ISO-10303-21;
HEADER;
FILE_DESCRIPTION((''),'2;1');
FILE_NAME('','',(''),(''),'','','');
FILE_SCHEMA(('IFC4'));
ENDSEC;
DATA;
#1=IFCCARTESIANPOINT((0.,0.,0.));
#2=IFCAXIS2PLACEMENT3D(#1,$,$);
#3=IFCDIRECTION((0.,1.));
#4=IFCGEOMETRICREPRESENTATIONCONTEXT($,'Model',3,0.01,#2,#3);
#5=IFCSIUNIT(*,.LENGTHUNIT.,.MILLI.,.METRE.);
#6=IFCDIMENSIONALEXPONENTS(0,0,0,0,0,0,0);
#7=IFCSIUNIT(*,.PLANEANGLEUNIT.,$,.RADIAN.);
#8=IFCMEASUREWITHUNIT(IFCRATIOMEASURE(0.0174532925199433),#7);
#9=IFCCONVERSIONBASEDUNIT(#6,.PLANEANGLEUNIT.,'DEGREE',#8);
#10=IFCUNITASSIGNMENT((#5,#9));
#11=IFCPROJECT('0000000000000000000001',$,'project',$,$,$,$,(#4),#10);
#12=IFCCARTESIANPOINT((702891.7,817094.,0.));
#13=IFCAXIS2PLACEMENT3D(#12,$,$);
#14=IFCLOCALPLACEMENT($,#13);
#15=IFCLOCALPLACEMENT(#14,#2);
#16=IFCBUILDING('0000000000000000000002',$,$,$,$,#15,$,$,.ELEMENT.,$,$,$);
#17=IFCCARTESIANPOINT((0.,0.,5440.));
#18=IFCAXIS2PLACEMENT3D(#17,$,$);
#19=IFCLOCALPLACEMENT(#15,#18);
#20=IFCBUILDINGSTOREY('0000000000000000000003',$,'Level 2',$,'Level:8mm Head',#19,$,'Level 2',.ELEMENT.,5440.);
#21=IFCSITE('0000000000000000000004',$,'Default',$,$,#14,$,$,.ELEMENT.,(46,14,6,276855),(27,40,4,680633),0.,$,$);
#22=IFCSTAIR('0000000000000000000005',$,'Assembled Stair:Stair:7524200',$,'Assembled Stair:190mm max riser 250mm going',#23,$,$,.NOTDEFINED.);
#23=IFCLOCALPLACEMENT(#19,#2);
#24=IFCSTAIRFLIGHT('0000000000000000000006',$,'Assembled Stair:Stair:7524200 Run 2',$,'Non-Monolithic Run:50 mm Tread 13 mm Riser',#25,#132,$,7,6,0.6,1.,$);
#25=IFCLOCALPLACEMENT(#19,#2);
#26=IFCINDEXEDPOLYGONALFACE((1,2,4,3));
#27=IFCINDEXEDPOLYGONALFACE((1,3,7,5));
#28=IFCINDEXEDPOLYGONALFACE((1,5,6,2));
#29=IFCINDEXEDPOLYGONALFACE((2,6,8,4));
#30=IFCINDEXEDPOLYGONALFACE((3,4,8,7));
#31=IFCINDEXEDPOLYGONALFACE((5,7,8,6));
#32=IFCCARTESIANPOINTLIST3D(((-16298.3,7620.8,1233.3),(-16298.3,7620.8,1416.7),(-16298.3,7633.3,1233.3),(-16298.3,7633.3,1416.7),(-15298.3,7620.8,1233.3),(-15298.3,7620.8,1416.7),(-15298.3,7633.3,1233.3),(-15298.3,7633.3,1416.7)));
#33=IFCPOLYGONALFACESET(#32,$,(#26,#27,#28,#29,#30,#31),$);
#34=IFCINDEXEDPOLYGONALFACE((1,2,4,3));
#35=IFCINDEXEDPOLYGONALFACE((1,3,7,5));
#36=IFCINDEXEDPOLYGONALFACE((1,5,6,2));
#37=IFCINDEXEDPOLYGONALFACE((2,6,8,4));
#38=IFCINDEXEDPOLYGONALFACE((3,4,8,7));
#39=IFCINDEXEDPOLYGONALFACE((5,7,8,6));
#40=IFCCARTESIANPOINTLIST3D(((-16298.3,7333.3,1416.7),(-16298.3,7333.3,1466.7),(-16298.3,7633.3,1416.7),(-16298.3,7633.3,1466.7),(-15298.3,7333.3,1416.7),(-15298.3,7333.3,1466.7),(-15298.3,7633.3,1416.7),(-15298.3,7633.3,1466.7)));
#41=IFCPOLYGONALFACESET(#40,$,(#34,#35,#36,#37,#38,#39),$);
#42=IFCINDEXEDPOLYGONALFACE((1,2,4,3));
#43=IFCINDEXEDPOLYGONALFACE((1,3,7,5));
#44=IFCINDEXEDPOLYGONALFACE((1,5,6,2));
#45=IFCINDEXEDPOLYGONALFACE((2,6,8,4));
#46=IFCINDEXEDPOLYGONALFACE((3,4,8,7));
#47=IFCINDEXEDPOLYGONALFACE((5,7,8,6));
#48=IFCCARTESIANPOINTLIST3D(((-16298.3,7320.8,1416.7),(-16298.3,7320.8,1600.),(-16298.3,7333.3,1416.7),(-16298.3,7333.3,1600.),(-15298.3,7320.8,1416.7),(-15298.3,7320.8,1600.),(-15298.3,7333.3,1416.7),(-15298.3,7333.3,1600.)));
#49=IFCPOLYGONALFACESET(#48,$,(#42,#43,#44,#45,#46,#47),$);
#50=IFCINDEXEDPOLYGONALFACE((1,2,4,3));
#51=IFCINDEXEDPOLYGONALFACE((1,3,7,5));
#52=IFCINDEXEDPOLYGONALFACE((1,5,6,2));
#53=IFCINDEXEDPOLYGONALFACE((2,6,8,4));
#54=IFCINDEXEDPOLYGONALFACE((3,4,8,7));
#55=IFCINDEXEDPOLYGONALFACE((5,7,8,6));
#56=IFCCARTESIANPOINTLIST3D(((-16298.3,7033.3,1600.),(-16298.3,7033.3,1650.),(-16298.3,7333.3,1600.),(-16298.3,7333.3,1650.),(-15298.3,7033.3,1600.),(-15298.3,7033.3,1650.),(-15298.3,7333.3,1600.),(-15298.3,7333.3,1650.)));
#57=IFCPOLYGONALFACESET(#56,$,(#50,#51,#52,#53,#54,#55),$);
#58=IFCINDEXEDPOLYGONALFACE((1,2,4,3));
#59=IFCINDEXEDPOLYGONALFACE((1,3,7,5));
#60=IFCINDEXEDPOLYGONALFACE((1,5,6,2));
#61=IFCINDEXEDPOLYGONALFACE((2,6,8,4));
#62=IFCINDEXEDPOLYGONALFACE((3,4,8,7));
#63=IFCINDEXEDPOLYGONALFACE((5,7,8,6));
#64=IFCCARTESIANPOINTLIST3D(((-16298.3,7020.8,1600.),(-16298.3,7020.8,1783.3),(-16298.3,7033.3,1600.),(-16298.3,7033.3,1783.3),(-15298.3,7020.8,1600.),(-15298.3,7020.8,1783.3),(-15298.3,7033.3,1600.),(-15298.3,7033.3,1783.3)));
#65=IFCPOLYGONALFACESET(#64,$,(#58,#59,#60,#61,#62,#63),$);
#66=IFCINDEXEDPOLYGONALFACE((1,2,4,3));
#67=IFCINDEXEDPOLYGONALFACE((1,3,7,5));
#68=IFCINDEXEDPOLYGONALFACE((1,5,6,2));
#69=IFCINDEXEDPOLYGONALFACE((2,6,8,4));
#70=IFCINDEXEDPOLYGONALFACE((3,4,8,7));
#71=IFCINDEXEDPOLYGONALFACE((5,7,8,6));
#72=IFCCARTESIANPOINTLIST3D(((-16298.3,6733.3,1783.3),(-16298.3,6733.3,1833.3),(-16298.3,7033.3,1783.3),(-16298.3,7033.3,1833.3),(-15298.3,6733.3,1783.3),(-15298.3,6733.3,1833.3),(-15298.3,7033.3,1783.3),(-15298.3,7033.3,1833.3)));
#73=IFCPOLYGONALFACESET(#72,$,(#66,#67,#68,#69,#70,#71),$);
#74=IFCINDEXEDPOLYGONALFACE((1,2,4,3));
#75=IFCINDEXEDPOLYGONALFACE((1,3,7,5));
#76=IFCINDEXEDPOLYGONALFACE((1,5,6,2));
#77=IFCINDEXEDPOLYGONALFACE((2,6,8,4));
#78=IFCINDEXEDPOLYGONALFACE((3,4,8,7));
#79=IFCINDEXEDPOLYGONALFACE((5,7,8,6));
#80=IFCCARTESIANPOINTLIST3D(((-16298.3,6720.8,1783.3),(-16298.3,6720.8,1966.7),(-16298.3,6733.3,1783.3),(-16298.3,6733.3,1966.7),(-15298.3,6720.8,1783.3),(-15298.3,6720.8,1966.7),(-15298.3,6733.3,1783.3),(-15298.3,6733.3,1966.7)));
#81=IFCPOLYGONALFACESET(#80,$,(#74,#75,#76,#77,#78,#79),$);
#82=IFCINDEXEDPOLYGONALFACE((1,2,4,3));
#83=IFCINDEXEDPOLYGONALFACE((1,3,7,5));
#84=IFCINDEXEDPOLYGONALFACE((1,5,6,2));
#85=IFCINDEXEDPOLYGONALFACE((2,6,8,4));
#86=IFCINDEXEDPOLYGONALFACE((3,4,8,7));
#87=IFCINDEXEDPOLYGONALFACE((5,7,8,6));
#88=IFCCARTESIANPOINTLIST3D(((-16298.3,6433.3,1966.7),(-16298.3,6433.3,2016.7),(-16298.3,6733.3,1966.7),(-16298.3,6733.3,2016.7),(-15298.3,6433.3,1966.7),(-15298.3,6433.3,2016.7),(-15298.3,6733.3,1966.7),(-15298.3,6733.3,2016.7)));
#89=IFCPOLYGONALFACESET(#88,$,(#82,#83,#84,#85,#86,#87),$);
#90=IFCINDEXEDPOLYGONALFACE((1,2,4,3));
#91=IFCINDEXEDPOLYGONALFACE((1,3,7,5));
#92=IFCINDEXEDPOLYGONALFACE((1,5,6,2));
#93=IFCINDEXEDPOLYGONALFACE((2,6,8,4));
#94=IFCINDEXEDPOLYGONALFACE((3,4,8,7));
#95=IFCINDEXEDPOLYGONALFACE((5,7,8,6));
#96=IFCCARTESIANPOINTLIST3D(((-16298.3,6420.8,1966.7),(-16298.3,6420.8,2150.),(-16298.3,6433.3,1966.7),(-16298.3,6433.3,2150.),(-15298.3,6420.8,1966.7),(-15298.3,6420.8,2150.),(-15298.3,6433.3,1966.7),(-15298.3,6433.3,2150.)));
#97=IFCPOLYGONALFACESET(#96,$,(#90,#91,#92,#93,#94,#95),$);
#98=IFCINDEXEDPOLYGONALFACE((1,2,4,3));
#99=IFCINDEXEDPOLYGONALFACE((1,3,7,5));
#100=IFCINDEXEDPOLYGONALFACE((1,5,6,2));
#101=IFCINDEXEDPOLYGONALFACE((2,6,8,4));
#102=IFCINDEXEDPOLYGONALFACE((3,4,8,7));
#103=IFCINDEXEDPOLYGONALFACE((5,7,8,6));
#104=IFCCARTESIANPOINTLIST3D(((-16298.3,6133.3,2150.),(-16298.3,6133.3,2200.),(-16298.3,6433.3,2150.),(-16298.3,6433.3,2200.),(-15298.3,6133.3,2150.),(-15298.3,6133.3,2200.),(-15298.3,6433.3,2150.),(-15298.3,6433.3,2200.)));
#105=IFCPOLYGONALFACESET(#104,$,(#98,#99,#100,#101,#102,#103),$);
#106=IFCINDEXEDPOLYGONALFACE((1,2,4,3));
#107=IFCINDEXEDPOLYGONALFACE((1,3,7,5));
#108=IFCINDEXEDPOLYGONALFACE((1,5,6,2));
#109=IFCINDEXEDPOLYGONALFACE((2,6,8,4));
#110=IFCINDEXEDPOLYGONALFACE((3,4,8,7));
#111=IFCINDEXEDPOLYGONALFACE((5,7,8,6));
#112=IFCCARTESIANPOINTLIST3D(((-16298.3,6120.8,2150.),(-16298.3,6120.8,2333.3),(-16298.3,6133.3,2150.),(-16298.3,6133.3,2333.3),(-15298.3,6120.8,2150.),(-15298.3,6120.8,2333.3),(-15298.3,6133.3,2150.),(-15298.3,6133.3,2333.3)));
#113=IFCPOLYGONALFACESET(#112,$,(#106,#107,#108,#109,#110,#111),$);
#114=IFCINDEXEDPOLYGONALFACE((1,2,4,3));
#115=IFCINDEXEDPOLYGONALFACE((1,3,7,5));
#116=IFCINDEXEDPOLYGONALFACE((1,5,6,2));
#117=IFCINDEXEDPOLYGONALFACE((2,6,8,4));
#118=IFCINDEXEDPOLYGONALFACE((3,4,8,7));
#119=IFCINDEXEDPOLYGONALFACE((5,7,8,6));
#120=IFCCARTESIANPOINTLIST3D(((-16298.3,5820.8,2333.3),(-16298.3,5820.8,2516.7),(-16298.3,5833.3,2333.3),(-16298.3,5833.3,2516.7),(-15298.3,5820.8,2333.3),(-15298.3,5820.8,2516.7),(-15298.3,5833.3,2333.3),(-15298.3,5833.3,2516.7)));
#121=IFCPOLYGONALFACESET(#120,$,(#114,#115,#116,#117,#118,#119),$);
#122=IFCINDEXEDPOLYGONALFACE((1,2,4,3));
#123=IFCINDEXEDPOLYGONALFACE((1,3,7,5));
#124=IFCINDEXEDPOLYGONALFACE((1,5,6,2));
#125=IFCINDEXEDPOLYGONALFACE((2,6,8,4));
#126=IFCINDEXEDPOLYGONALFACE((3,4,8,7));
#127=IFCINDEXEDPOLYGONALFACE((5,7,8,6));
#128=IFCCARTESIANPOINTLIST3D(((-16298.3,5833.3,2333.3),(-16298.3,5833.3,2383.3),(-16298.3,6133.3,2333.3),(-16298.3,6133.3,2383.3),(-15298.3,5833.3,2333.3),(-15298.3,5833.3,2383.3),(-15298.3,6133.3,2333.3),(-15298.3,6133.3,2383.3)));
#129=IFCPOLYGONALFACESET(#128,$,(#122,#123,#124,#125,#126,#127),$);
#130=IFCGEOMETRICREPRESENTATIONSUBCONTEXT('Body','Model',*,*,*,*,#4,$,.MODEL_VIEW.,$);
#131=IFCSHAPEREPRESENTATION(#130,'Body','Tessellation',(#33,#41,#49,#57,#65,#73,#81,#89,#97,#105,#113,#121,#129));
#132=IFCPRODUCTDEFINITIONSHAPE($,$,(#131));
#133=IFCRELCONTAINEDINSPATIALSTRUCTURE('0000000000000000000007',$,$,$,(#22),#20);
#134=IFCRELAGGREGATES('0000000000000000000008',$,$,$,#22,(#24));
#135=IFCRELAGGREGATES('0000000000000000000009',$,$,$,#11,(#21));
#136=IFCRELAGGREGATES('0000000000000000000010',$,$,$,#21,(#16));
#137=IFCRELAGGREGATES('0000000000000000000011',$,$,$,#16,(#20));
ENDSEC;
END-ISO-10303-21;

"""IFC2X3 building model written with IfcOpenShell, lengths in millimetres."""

from ifc_helpers import new_model, entity, si_unit, converted_unit, direction, frame, frame_2d, origin, place, context, subcontext, project, spatial, rectangle, extrude, element, aggregate, save


model = new_model("IFC2X3")

# Units and contexts
model_context = context("Model", 3, precision=0.01, world=origin(), true_north=direction((0.0, 1.0)))
body_context = subcontext(model_context, "Body", "Model", "MODEL_VIEW")
ifc_project = project(units=[si_unit("LENGTHUNIT", "METRE", prefix="MILLI"), converted_unit("PLANEANGLEUNIT", "DEGREE", entity("IfcRatioMeasure", 0.0174532925199433), si_unit("PLANEANGLEUNIT", "RADIAN"), dimensions=[0, 0, 0, 0, 0, 0, 0])], contexts=[model_context])

# Site, building, storey
site_placement = place(None, frame((702891.7, 817094.0, 0.0)))
site = spatial("IfcSite", under=ifc_project, at=site_placement, Name="Default", CompositionType="ELEMENT", RefLatitude=(46, 14, 6, 276855), RefLongitude=(27, 40, 4, 680633), RefElevation=0.0)
building_placement = place(site_placement, origin())
building = spatial("IfcBuilding", under=site, at=building_placement, CompositionType="ELEMENT")
storey_placement = place(building_placement, frame((0.0, 0.0, 5440.0)))
storey = spatial("IfcBuildingStorey", under=building, at=storey_placement, Name="Level 2", ObjectType="Level:8mm Head", LongName="Level 2", CompositionType="ELEMENT", Elevation=5440.0)

# Stair
stair_1_placement = place(storey_placement, origin())
stair_1 = element("IfcStair", 1, at=stair_1_placement, inside=storey, Name="Assembled Stair:Stair:7524200", ObjectType="Assembled Stair:190mm max riser 250mm going", ShapeType="NOTDEFINED")

# Stair flight
stair_flight_1_placement = place(stair_1_placement, origin())
stair_flight_1 = element("IfcStairFlight", 2, at=stair_flight_1_placement, Name="Assembled Stair:Stair:7524200 Run 2", ObjectType="Non-Monolithic Run:50 mm Tread 13 mm Riser", NumberOfRiser=7, NumberOfTreads=6, RiserHeight=0.6, TreadLength=1.0, context=body_context, shape_type="SweptSolid", body=[
    extrude(rectangle(XDim=1000.0, YDim=12.5, at=frame_2d((0.0, 0.0), x_axis=(1.0, 0.0))), frame((-15798.3, 7627.1, 1233.3)), (0.0, 0.0, 1.0), 183.3),
    extrude(rectangle(XDim=300.0, YDim=1000.0, at=frame_2d((0.0, 0.0), x_axis=(1.0, 0.0))), frame((-15798.3, 7483.3, 1416.7), z_axis=(0.0, 0.0, 1.0), x_axis=(0.0, 1.0, 0.0)), (0.0, 0.0, 1.0), 50.0),
    extrude(rectangle(XDim=1000.0, YDim=12.5, at=frame_2d((0.0, 0.0), x_axis=(1.0, 0.0))), frame((-15798.3, 7327.1, 1416.7)), (0.0, 0.0, 1.0), 183.3),
    extrude(rectangle(XDim=300.0, YDim=1000.0, at=frame_2d((0.0, 0.0), x_axis=(1.0, 0.0))), frame((-15798.3, 7183.3, 1600.0), z_axis=(0.0, 0.0, 1.0), x_axis=(0.0, 1.0, 0.0)), (0.0, 0.0, 1.0), 50.0),
    extrude(rectangle(XDim=1000.0, YDim=12.5, at=frame_2d((0.0, 0.0), x_axis=(1.0, 0.0))), frame((-15798.3, 7027.1, 1600.0)), (0.0, 0.0, 1.0), 183.3),
    extrude(rectangle(XDim=300.0, YDim=1000.0, at=frame_2d((0.0, 0.0), x_axis=(1.0, 0.0))), frame((-15798.3, 6883.3, 1783.3), z_axis=(0.0, 0.0, 1.0), x_axis=(0.0, 1.0, 0.0)), (0.0, 0.0, 1.0), 50.0),
    extrude(rectangle(XDim=1000.0, YDim=12.5, at=frame_2d((0.0, 0.0), x_axis=(1.0, 0.0))), frame((-15798.3, 6727.1, 1783.3)), (0.0, 0.0, 1.0), 183.3),
    extrude(rectangle(XDim=300.0, YDim=1000.0, at=frame_2d((0.0, 0.0), x_axis=(1.0, 0.0))), frame((-15798.3, 6583.3, 1966.7), z_axis=(0.0, 0.0, 1.0), x_axis=(0.0, 1.0, 0.0)), (0.0, 0.0, 1.0), 50.0),
    extrude(rectangle(XDim=1000.0, YDim=12.5, at=frame_2d((0.0, 0.0), x_axis=(1.0, 0.0))), frame((-15798.3, 6427.1, 1966.7)), (0.0, 0.0, 1.0), 183.3),
    extrude(rectangle(XDim=300.0, YDim=1000.0, at=frame_2d((0.0, 0.0), x_axis=(1.0, 0.0))), frame((-15798.3, 6283.3, 2150.0), z_axis=(0.0, 0.0, 1.0), x_axis=(0.0, 1.0, 0.0)), (0.0, 0.0, 1.0), 50.0),
    extrude(rectangle(XDim=1000.0, YDim=12.5, at=frame_2d((0.0, 0.0), x_axis=(1.0, 0.0))), frame((-15798.3, 6127.1, 2150.0)), (0.0, 0.0, 1.0), 183.3),
    extrude(rectangle(XDim=1000.0, YDim=12.5, at=frame_2d((0.0, 0.0), x_axis=(1.0, 0.0))), frame((-15798.3, 5827.1, 2333.3)), (0.0, 0.0, 1.0), 183.3),
    extrude(rectangle(XDim=300.0, YDim=1000.0, at=frame_2d((0.0, 0.0), x_axis=(1.0, 0.0))), frame((-15798.3, 5983.3, 2333.3), z_axis=(0.0, 0.0, 1.0), x_axis=(0.0, 1.0, 0.0)), (0.0, 0.0, 1.0), 50.0),
])
aggregate(stair_1, [stair_flight_1])

save(model, "model.ifc")
